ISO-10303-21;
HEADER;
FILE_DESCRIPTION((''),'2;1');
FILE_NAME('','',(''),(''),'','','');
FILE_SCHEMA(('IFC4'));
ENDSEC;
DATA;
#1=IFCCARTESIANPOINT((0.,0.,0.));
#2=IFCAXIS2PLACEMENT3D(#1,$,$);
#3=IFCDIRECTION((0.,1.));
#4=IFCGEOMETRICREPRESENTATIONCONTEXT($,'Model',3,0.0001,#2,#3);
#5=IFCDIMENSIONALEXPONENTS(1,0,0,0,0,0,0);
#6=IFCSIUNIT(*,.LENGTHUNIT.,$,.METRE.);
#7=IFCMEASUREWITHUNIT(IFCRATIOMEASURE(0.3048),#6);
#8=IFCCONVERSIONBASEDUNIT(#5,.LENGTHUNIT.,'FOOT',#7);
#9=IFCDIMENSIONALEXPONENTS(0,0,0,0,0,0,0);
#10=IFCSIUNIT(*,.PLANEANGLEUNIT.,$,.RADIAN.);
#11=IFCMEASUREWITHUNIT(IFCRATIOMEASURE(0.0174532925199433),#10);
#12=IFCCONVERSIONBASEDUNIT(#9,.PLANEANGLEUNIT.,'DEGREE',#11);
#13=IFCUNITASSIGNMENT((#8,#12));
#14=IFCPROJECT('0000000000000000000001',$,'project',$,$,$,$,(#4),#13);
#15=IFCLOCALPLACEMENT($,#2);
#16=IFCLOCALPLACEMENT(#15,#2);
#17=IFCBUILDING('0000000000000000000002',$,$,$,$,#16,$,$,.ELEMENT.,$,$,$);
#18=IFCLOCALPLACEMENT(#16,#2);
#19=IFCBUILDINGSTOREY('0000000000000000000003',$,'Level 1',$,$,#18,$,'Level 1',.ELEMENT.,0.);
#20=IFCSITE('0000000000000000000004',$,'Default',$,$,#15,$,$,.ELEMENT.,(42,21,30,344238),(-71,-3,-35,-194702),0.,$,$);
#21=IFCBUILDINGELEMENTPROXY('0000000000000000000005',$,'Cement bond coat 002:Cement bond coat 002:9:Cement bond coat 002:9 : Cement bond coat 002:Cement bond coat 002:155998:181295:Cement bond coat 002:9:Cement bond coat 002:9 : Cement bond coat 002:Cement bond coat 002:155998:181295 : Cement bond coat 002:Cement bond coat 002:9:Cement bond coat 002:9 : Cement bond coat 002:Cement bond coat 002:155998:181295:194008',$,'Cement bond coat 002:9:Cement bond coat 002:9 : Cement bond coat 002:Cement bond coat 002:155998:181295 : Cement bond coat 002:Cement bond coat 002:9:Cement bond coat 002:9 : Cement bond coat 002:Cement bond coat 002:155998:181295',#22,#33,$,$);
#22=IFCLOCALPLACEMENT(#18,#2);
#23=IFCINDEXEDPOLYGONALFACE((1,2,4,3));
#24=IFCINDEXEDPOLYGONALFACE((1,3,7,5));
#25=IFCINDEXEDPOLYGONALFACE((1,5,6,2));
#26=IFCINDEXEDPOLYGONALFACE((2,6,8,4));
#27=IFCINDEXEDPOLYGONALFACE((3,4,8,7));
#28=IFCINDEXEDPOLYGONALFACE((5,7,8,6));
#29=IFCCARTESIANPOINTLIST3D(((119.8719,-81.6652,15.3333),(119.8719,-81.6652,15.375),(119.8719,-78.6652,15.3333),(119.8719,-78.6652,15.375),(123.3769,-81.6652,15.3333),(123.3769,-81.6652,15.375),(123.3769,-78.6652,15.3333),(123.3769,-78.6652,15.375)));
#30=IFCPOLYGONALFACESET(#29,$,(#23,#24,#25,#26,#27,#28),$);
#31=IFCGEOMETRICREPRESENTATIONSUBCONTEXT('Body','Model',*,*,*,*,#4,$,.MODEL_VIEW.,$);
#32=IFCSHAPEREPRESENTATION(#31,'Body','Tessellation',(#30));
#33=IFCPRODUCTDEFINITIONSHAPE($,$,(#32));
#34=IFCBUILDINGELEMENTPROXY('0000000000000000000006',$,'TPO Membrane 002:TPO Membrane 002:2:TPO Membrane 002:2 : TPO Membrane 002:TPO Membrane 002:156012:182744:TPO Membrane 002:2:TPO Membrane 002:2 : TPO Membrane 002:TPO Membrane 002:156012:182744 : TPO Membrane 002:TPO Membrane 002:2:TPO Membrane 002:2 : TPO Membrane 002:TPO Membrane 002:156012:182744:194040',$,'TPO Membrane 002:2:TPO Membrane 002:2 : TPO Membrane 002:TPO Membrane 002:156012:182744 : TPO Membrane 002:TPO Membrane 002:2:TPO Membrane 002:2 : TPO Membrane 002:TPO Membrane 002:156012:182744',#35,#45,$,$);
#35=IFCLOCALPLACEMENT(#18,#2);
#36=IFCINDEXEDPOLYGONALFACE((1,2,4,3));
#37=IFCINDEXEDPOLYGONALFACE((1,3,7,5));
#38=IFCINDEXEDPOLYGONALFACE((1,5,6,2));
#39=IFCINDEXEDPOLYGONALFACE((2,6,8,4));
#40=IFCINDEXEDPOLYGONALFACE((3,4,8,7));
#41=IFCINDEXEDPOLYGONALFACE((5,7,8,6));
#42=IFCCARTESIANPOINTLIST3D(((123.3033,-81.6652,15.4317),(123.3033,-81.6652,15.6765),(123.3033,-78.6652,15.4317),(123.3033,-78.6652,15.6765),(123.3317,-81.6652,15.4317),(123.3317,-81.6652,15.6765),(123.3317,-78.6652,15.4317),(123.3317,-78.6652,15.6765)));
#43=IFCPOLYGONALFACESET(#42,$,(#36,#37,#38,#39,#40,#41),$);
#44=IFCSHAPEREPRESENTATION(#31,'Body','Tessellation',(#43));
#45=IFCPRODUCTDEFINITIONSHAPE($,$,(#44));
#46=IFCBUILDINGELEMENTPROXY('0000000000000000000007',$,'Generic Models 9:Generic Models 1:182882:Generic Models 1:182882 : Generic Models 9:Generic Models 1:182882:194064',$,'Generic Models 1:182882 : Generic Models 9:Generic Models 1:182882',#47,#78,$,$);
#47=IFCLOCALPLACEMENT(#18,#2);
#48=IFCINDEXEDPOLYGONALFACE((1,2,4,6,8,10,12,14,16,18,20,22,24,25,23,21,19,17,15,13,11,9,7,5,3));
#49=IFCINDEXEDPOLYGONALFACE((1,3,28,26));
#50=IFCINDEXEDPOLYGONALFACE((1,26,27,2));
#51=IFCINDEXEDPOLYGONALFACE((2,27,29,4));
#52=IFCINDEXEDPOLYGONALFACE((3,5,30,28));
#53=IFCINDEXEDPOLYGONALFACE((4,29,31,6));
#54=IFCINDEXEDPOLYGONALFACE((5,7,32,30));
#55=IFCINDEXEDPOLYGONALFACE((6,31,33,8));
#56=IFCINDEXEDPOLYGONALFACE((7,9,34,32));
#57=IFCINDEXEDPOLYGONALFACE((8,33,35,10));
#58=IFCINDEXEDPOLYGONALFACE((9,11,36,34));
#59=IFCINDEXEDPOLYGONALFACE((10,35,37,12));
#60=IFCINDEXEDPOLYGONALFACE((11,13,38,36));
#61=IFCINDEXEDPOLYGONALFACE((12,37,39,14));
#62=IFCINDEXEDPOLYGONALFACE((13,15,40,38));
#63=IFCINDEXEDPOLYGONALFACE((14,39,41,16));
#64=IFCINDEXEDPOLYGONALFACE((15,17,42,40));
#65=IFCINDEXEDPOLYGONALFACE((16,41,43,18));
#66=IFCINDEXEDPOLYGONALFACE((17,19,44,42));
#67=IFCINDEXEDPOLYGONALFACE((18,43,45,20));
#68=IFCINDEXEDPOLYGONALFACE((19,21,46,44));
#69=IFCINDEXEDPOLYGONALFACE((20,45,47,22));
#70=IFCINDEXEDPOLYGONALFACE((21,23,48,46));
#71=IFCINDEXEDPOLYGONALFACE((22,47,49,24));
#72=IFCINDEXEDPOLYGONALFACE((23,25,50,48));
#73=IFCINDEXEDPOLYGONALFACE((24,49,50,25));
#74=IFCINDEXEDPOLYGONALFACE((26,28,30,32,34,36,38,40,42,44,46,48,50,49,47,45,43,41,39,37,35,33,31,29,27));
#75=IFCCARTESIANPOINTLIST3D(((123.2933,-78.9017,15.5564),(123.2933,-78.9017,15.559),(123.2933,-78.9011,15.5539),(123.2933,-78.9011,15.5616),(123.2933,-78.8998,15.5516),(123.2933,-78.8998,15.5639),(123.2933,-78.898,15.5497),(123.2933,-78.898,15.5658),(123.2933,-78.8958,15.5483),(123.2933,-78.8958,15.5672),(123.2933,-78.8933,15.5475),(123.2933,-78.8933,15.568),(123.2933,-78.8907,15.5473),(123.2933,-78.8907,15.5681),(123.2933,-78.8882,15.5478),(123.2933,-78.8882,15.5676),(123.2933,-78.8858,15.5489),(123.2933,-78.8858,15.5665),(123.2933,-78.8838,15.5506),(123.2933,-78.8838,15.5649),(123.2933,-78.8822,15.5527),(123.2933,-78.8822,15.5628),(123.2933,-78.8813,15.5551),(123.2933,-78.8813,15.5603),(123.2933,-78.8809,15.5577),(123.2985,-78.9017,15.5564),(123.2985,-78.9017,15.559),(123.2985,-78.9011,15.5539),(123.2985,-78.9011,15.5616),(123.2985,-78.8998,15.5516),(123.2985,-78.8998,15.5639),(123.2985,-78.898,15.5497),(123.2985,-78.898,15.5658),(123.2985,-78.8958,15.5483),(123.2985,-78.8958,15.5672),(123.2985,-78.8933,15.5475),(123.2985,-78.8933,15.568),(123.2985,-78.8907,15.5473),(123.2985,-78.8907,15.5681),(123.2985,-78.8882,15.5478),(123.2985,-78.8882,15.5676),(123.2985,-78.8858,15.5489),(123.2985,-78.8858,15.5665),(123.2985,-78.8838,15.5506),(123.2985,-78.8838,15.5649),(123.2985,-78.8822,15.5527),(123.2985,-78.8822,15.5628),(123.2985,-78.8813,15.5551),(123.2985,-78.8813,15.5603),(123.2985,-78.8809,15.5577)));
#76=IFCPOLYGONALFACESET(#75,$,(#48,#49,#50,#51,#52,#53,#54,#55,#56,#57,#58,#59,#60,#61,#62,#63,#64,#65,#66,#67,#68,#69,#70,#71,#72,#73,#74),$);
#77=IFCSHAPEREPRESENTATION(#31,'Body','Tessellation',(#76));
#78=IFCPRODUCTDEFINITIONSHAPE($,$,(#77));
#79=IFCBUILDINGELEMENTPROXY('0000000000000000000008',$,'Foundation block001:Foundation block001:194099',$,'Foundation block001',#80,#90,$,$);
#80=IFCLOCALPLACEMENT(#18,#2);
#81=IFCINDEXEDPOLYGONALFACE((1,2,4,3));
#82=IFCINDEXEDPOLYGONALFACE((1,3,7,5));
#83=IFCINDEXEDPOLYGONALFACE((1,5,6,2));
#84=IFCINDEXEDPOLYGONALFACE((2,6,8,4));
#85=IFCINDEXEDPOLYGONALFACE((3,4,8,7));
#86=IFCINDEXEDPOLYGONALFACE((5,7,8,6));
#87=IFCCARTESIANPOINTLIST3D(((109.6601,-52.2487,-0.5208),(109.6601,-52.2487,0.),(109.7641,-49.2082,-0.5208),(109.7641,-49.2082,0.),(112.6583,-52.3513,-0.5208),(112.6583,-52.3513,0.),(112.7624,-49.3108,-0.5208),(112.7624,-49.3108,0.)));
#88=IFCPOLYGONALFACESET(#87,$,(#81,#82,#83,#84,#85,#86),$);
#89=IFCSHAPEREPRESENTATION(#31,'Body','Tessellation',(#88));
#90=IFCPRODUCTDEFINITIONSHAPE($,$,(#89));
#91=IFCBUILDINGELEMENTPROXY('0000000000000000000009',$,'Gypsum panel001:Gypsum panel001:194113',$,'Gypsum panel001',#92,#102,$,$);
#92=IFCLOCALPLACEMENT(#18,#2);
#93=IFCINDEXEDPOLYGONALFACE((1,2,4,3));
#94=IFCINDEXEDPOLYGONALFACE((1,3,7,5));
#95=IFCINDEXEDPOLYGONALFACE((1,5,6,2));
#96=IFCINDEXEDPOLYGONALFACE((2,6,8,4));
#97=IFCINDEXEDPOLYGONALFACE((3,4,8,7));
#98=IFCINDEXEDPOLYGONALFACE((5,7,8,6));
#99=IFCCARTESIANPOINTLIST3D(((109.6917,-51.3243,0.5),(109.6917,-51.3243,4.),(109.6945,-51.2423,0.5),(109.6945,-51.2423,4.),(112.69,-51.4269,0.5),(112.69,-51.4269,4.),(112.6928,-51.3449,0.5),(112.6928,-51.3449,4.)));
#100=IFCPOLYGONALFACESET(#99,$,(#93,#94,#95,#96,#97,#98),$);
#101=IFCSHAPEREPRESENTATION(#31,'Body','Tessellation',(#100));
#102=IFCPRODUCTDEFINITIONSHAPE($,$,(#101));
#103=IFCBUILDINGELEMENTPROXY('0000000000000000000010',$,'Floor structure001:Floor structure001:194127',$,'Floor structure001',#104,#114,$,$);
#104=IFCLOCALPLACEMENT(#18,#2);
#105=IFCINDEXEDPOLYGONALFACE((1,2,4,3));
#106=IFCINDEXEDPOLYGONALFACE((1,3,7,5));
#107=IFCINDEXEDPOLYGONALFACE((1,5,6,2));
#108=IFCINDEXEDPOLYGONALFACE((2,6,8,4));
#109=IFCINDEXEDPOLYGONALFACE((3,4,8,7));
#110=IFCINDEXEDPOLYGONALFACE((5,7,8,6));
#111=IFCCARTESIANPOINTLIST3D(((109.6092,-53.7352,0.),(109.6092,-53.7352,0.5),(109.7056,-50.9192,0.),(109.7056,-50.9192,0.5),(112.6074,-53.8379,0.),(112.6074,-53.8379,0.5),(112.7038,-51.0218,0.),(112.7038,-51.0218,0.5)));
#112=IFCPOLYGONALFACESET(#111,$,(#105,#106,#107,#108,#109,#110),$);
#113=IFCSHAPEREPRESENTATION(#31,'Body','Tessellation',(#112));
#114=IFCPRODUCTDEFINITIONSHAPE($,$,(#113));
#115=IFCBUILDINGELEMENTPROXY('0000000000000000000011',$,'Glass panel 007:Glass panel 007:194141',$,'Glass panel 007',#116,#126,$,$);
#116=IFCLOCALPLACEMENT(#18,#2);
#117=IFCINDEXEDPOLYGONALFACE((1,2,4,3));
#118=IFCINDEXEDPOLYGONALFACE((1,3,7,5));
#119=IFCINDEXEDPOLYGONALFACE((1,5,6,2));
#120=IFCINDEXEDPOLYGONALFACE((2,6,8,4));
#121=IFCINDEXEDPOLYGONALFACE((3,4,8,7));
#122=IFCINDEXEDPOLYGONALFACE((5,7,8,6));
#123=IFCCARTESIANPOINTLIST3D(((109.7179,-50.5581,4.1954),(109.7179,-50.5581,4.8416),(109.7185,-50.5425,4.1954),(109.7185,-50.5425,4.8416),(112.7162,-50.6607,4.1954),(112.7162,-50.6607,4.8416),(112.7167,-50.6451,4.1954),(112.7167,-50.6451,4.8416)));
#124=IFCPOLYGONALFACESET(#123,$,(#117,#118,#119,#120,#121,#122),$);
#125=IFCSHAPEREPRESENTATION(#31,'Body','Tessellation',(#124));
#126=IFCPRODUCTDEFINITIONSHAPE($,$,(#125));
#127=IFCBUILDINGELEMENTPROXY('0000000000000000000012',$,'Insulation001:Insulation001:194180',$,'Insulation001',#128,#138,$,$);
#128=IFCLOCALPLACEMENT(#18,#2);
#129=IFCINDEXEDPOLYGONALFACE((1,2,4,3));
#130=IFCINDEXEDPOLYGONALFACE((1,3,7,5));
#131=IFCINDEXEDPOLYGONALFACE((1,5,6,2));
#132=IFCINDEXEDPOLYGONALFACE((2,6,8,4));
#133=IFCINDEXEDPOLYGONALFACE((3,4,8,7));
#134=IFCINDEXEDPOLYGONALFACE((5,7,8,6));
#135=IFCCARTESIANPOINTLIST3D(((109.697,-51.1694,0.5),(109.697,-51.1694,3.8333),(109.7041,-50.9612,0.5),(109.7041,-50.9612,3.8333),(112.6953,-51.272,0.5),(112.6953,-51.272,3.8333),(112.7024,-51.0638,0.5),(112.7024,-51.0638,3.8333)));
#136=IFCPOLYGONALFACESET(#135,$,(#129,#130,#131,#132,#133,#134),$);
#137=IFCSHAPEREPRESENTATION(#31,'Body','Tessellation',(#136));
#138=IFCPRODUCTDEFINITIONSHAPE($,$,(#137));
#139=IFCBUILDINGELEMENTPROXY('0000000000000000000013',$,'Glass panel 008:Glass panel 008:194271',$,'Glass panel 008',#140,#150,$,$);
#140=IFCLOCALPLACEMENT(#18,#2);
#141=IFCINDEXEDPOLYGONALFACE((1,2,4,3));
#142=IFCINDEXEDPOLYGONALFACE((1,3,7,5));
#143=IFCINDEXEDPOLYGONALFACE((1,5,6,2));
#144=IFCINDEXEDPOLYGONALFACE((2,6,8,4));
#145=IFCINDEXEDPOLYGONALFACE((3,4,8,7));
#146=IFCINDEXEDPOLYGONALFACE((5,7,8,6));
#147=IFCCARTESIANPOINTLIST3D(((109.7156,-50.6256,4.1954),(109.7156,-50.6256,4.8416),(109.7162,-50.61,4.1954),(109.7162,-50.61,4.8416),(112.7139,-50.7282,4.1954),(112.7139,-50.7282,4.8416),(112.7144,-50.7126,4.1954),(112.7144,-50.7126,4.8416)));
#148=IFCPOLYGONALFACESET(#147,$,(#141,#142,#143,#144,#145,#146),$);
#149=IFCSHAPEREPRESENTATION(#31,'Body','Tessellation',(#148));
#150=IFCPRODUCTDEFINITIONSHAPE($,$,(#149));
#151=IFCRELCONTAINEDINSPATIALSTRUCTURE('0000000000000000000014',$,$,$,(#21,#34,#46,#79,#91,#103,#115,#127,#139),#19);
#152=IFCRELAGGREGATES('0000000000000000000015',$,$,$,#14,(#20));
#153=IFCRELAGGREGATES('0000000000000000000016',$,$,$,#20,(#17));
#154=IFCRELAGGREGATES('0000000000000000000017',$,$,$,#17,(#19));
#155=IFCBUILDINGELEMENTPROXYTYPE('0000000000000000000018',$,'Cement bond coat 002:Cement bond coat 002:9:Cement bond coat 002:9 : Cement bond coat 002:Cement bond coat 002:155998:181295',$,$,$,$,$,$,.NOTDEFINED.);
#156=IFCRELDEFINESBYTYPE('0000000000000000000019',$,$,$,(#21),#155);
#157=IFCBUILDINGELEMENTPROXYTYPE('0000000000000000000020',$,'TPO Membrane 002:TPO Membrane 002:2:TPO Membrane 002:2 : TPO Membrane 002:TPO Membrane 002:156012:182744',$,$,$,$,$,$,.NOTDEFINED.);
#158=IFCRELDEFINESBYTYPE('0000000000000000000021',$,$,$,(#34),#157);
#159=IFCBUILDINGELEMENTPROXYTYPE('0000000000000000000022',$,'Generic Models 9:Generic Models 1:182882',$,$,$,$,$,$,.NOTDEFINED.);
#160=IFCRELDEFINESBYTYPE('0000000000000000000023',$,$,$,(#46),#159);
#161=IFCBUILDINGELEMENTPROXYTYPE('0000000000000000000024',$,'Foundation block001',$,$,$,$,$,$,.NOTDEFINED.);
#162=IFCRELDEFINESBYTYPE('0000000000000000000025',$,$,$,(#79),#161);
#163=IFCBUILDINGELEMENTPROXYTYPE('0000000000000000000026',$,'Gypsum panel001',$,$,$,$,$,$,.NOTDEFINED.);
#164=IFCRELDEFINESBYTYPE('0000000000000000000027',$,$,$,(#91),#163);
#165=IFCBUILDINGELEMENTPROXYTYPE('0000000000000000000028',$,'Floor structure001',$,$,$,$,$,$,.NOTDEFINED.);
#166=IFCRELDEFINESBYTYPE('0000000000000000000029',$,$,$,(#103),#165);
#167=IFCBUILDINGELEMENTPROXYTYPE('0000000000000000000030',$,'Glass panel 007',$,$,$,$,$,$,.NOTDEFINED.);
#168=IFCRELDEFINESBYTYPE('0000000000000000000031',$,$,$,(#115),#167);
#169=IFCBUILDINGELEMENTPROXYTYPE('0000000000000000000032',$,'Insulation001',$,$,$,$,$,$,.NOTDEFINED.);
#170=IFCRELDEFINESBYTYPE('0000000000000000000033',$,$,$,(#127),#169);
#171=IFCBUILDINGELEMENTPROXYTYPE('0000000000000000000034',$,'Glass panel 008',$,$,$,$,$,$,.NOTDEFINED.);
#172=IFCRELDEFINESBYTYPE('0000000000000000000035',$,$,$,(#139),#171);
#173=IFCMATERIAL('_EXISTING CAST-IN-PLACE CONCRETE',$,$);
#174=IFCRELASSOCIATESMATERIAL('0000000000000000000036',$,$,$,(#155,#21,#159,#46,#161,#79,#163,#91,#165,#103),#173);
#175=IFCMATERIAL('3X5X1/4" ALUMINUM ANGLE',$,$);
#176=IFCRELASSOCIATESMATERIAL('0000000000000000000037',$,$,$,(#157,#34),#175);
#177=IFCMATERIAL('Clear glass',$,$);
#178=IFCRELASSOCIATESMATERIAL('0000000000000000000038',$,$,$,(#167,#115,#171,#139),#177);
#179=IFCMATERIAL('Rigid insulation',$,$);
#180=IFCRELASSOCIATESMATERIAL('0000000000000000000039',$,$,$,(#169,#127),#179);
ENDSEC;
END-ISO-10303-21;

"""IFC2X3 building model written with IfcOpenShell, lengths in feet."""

from ifc_helpers import new_model, entity, si_unit, converted_unit, direction, frame, frame_2d, origin, origin_2d_with_axis, place, context, subcontext, project, spatial, polyline, rectangle, outline, extrude, source, transform, mapped, material, type_object, type_shapes, element, save


model = new_model("IFC2X3")

# Units and contexts
model_context = context("Model", 3, precision=0.0001, world=origin(), true_north=direction((0.0, 1.0)))
body_context = subcontext(model_context, "Body", "Model", "MODEL_VIEW")
ifc_project = project(units=[converted_unit("LENGTHUNIT", "FOOT", entity("IfcRatioMeasure", 0.3048), si_unit("LENGTHUNIT", "METRE"), dimensions=[1, 0, 0, 0, 0, 0, 0]), converted_unit("PLANEANGLEUNIT", "DEGREE", entity("IfcRatioMeasure", 0.0174532925199433), si_unit("PLANEANGLEUNIT", "RADIAN"), dimensions=[0, 0, 0, 0, 0, 0, 0])], contexts=[model_context])

# Site, building, storey
site_placement = place(None, origin())
site = spatial("IfcSite", under=ifc_project, at=site_placement, Name="Default", CompositionType="ELEMENT", RefLatitude=(42, 21, 30, 344238), RefLongitude=(-71, -3, -35, -194702), RefElevation=0.0)
building_placement = place(site_placement, origin())
building = spatial("IfcBuilding", under=site, at=building_placement, CompositionType="ELEMENT")
storey_placement = place(building_placement, origin())
storey = spatial("IfcBuildingStorey", under=building, at=storey_placement, Name="Level 1", LongName="Level 1", CompositionType="ELEMENT", Elevation=0.0)

# Building element proxies
ifc_material_1 = material(Name="3X5X1/4\" ALUMINUM ANGLE")
ifc_material_2 = material(Name="_EXISTING CAST-IN-PLACE CONCRETE")
building_element_proxy_type_1 = type_object("IfcBuildingElementProxyType", Name="Cement bond coat 002:Cement bond coat 002:9:Cement bond coat 002:9 : Cement bond coat 002:Cement bond coat 002:155998:181295", PredefinedType="NOTDEFINED", material=ifc_material_2)
shared_shape_1 = source(origin(), body_context, "Body", "SweptSolid", [
    extrude(rectangle(XDim=3.505, YDim=3.0, at=frame_2d((0.0, 0.0), x_axis=(1.0, 0.0))), frame((121.6244, -80.1652, 15.3333), z_axis=(0.0, 0.0, 1.0), x_axis=(-1.0, 0.0, 0.0)), (0.0, 0.0, 1.0), 0.0417),
])
type_shapes(building_element_proxy_type_1, [shared_shape_1])
proxy_1_placement = place(storey_placement, origin())
element("IfcBuildingElementProxy", 1, at=proxy_1_placement, inside=storey, type_object=building_element_proxy_type_1, material=ifc_material_2, Name="Cement bond coat 002:Cement bond coat 002:9:Cement bond coat 002:9 : Cement bond coat 002:Cement bond coat 002:155998:181295:Cement bond coat 002:9:Cement bond coat 002:9 : Cement bond coat 002:Cement bond coat 002:155998:181295 : Cement bond coat 002:Cement bond coat 002:9:Cement bond coat 002:9 : Cement bond coat 002:Cement bond coat 002:155998:181295:194008", ObjectType="Cement bond coat 002:9:Cement bond coat 002:9 : Cement bond coat 002:Cement bond coat 002:155998:181295 : Cement bond coat 002:Cement bond coat 002:9:Cement bond coat 002:9 : Cement bond coat 002:Cement bond coat 002:155998:181295", context=body_context, shape_type="MappedRepresentation", body=[
    mapped(shared_shape_1, transform((0.0, 0.0, 0.0), scale=1.0)),
])
building_element_proxy_type_2 = type_object("IfcBuildingElementProxyType", Name="TPO Membrane 002:TPO Membrane 002:2:TPO Membrane 002:2 : TPO Membrane 002:TPO Membrane 002:156012:182744", PredefinedType="NOTDEFINED", material=ifc_material_1)
shared_shape_2 = source(origin(), body_context, "Body", "SweptSolid", [
    extrude(rectangle(XDim=0.0284, YDim=3.0, at=frame_2d((0.0, 0.0), x_axis=(1.0, 0.0))), frame((123.3175, -80.1652, 15.4317)), (0.0, 0.0, 1.0), 0.2449),
])
type_shapes(building_element_proxy_type_2, [shared_shape_2])
proxy_2_placement = place(storey_placement, origin())
element("IfcBuildingElementProxy", 2, at=proxy_2_placement, inside=storey, type_object=building_element_proxy_type_2, material=ifc_material_1, Name="TPO Membrane 002:TPO Membrane 002:2:TPO Membrane 002:2 : TPO Membrane 002:TPO Membrane 002:156012:182744:TPO Membrane 002:2:TPO Membrane 002:2 : TPO Membrane 002:TPO Membrane 002:156012:182744 : TPO Membrane 002:TPO Membrane 002:2:TPO Membrane 002:2 : TPO Membrane 002:TPO Membrane 002:156012:182744:194040", ObjectType="TPO Membrane 002:2:TPO Membrane 002:2 : TPO Membrane 002:TPO Membrane 002:156012:182744 : TPO Membrane 002:TPO Membrane 002:2:TPO Membrane 002:2 : TPO Membrane 002:TPO Membrane 002:156012:182744", context=body_context, shape_type="MappedRepresentation", body=[
    mapped(shared_shape_2, transform((0.0, 0.0, 0.0), scale=1.0)),
])
building_element_proxy_type_3 = type_object("IfcBuildingElementProxyType", Name="Generic Models 9:Generic Models 1:182882", PredefinedType="NOTDEFINED", material=ifc_material_2)
shared_shape_3 = source(origin(), body_context, "Body", "SweptSolid", [
    extrude(outline(polyline([(-0.0013, -0.0103), (0.0013, -0.0103), (0.0038, -0.0097), (0.0061, -0.0084), (0.008, -0.0066), (0.0094, -0.0044), (0.0102, -0.0019), (0.0104, 0.0007), (0.0099, 0.0032), (0.0088, 0.0056), (0.0071, 0.0076), (0.005, 0.0091), (0.0026, 0.0101), (0.0, 0.0104), (-0.0026, 0.0101), (-0.005, 0.0091), (-0.0071, 0.0076), (-0.0088, 0.0056), (-0.0099, 0.0032), (-0.0104, 0.0006), (-0.0102, -0.002), (-0.0094, -0.0044), (-0.008, -0.0067), (-0.0061, -0.0084), (-0.0038, -0.0097), (-0.0013, -0.0103)])), frame((123.2933, -78.8914, 15.5577), z_axis=(1.0, 0.0, 0.0), x_axis=(0.0, -0.367044, 0.930204)), (0.0, 0.0, 1.0), 0.0052),
])
type_shapes(building_element_proxy_type_3, [shared_shape_3])
proxy_3_placement = place(storey_placement, origin())
element("IfcBuildingElementProxy", 3, at=proxy_3_placement, inside=storey, type_object=building_element_proxy_type_3, material=ifc_material_2, Name="Generic Models 9:Generic Models 1:182882:Generic Models 1:182882 : Generic Models 9:Generic Models 1:182882:194064", ObjectType="Generic Models 1:182882 : Generic Models 9:Generic Models 1:182882", context=body_context, shape_type="MappedRepresentation", body=[
    mapped(shared_shape_3, transform((0.0, 0.0, 0.0), scale=1.0)),
])
building_element_proxy_type_4 = type_object("IfcBuildingElementProxyType", Name="Foundation block001", PredefinedType="NOTDEFINED", material=ifc_material_2)
shared_shape_4 = source(origin(), body_context, "Body", "SweptSolid", [
    extrude(rectangle(XDim=3.0, YDim=3.0422, at=frame_2d((0.0, 0.0), x_axis=(1.0, 0.0))), frame((111.2112, -50.7798, -0.5208), z_axis=(0.0, 0.0, 1.0), x_axis=(0.999415, -0.034202, 0.0)), (0.0, 0.0, 1.0), 0.5208),
])
type_shapes(building_element_proxy_type_4, [shared_shape_4])
proxy_4_placement = place(storey_placement, origin())
element("IfcBuildingElementProxy", 4, at=proxy_4_placement, inside=storey, type_object=building_element_proxy_type_4, material=ifc_material_2, Name="Foundation block001:Foundation block001:194099", ObjectType="Foundation block001", context=body_context, shape_type="MappedRepresentation", body=[
    mapped(shared_shape_4, transform((0.0, 0.0, 0.0), scale=1.0)),
])
building_element_proxy_type_5 = type_object("IfcBuildingElementProxyType", Name="Gypsum panel001", PredefinedType="NOTDEFINED", material=ifc_material_2)
shared_shape_5 = source(origin(), body_context, "Body", "SweptSolid", [
    extrude(rectangle(XDim=3.0, YDim=0.082, at=frame_2d((0.0, 0.0), x_axis=(1.0, 0.0))), frame((111.1922, -51.3346, 0.5), z_axis=(0.0, 0.0, 1.0), x_axis=(0.999415, -0.034202, 0.0)), (0.0, 0.0, 1.0), 3.5),
])
type_shapes(building_element_proxy_type_5, [shared_shape_5])
proxy_5_placement = place(storey_placement, origin())
element("IfcBuildingElementProxy", 5, at=proxy_5_placement, inside=storey, type_object=building_element_proxy_type_5, material=ifc_material_2, Name="Gypsum panel001:Gypsum panel001:194113", ObjectType="Gypsum panel001", context=body_context, shape_type="MappedRepresentation", body=[
    mapped(shared_shape_5, transform((0.0, 0.0, 0.0), scale=1.0)),
])
building_element_proxy_type_6 = type_object("IfcBuildingElementProxyType", Name="Floor structure001", PredefinedType="NOTDEFINED", material=ifc_material_2)
shared_shape_6 = source(origin(), body_context, "Body", "SweptSolid", [
    extrude(rectangle(XDim=3.0, YDim=2.8177, at=frame_2d((0.0, 0.0), x_axis=(1.0, 0.0))), frame((111.1565, -52.3785, 0.0), z_axis=(0.0, 0.0, 1.0), x_axis=(0.999415, -0.034202, 0.0)), (0.0, 0.0, 1.0), 0.5),
])
type_shapes(building_element_proxy_type_6, [shared_shape_6])
proxy_6_placement = place(storey_placement, origin())
element("IfcBuildingElementProxy", 6, at=proxy_6_placement, inside=storey, type_object=building_element_proxy_type_6, material=ifc_material_2, Name="Floor structure001:Floor structure001:194127", ObjectType="Floor structure001", context=body_context, shape_type="MappedRepresentation", body=[
    mapped(shared_shape_6, transform((0.0, 0.0, 0.0), scale=1.0)),
])
ifc_material_3 = material(Name="Clear glass")
building_element_proxy_type_7 = type_object("IfcBuildingElementProxyType", Name="Glass panel 007", PredefinedType="NOTDEFINED", material=ifc_material_3)
shared_shape_7 = source(origin(), body_context, "Body", "SweptSolid", [
    extrude(rectangle(XDim=3.0, YDim=0.0156, at=frame_2d((0.0, 0.0), x_axis=(1.0, 0.0))), frame((111.2173, -50.6016, 4.1954), z_axis=(0.0, 0.0, 1.0), x_axis=(0.999415, -0.034202, 0.0)), (0.0, 0.0, 1.0), 0.6462),
])
type_shapes(building_element_proxy_type_7, [shared_shape_7])
proxy_7_placement = place(storey_placement, origin())
element("IfcBuildingElementProxy", 7, at=proxy_7_placement, inside=storey, type_object=building_element_proxy_type_7, material=ifc_material_3, Name="Glass panel 007:Glass panel 007:194141", ObjectType="Glass panel 007", context=body_context, shape_type="MappedRepresentation", body=[
    mapped(shared_shape_7, transform((0.0, 0.0, 0.0), scale=1.0)),
])
ifc_material_4 = material(Name="Rigid insulation")
building_element_proxy_type_8 = type_object("IfcBuildingElementProxyType", Name="Insulation001", PredefinedType="NOTDEFINED", material=ifc_material_4)
shared_shape_8 = source(origin(), body_context, "Body", "SweptSolid", [
    extrude(rectangle(XDim=3.0, YDim=0.2083, at=frame_2d((0.0, 0.0), x_axis=(1.0, 0.0))), frame((111.1997, -51.1166, 0.5), z_axis=(0.0, 0.0, 1.0), x_axis=(0.999415, -0.034202, 0.0)), (0.0, 0.0, 1.0), 3.3333),
])
type_shapes(building_element_proxy_type_8, [shared_shape_8])
proxy_8_placement = place(storey_placement, origin())
element("IfcBuildingElementProxy", 8, at=proxy_8_placement, inside=storey, type_object=building_element_proxy_type_8, material=ifc_material_4, Name="Insulation001:Insulation001:194180", ObjectType="Insulation001", context=body_context, shape_type="MappedRepresentation", body=[
    mapped(shared_shape_8, transform((0.0, 0.0, 0.0), scale=1.0)),
])
building_element_proxy_type_9 = type_object("IfcBuildingElementProxyType", Name="Glass panel 008", PredefinedType="NOTDEFINED", material=ifc_material_3)
shared_shape_9 = source(origin(), body_context, "Body", "SweptSolid", [
    extrude(rectangle(XDim=3.0, YDim=0.0156, at=origin_2d_with_axis()), frame((111.215, -50.6691, 4.1954), z_axis=(0.0, 0.0, 1.0), x_axis=(0.999415, -0.034202, 0.0)), (0.0, 0.0, 1.0), 0.6462),
])
type_shapes(building_element_proxy_type_9, [shared_shape_9])
proxy_9_placement = place(storey_placement, origin())
element("IfcBuildingElementProxy", 9, at=proxy_9_placement, inside=storey, type_object=building_element_proxy_type_9, material=ifc_material_3, Name="Glass panel 008:Glass panel 008:194271", ObjectType="Glass panel 008", context=body_context, shape_type="MappedRepresentation", body=[
    mapped(shared_shape_9, transform((0.0, 0.0, 0.0), scale=1.0)),
])

save(model, "model.ifc")
